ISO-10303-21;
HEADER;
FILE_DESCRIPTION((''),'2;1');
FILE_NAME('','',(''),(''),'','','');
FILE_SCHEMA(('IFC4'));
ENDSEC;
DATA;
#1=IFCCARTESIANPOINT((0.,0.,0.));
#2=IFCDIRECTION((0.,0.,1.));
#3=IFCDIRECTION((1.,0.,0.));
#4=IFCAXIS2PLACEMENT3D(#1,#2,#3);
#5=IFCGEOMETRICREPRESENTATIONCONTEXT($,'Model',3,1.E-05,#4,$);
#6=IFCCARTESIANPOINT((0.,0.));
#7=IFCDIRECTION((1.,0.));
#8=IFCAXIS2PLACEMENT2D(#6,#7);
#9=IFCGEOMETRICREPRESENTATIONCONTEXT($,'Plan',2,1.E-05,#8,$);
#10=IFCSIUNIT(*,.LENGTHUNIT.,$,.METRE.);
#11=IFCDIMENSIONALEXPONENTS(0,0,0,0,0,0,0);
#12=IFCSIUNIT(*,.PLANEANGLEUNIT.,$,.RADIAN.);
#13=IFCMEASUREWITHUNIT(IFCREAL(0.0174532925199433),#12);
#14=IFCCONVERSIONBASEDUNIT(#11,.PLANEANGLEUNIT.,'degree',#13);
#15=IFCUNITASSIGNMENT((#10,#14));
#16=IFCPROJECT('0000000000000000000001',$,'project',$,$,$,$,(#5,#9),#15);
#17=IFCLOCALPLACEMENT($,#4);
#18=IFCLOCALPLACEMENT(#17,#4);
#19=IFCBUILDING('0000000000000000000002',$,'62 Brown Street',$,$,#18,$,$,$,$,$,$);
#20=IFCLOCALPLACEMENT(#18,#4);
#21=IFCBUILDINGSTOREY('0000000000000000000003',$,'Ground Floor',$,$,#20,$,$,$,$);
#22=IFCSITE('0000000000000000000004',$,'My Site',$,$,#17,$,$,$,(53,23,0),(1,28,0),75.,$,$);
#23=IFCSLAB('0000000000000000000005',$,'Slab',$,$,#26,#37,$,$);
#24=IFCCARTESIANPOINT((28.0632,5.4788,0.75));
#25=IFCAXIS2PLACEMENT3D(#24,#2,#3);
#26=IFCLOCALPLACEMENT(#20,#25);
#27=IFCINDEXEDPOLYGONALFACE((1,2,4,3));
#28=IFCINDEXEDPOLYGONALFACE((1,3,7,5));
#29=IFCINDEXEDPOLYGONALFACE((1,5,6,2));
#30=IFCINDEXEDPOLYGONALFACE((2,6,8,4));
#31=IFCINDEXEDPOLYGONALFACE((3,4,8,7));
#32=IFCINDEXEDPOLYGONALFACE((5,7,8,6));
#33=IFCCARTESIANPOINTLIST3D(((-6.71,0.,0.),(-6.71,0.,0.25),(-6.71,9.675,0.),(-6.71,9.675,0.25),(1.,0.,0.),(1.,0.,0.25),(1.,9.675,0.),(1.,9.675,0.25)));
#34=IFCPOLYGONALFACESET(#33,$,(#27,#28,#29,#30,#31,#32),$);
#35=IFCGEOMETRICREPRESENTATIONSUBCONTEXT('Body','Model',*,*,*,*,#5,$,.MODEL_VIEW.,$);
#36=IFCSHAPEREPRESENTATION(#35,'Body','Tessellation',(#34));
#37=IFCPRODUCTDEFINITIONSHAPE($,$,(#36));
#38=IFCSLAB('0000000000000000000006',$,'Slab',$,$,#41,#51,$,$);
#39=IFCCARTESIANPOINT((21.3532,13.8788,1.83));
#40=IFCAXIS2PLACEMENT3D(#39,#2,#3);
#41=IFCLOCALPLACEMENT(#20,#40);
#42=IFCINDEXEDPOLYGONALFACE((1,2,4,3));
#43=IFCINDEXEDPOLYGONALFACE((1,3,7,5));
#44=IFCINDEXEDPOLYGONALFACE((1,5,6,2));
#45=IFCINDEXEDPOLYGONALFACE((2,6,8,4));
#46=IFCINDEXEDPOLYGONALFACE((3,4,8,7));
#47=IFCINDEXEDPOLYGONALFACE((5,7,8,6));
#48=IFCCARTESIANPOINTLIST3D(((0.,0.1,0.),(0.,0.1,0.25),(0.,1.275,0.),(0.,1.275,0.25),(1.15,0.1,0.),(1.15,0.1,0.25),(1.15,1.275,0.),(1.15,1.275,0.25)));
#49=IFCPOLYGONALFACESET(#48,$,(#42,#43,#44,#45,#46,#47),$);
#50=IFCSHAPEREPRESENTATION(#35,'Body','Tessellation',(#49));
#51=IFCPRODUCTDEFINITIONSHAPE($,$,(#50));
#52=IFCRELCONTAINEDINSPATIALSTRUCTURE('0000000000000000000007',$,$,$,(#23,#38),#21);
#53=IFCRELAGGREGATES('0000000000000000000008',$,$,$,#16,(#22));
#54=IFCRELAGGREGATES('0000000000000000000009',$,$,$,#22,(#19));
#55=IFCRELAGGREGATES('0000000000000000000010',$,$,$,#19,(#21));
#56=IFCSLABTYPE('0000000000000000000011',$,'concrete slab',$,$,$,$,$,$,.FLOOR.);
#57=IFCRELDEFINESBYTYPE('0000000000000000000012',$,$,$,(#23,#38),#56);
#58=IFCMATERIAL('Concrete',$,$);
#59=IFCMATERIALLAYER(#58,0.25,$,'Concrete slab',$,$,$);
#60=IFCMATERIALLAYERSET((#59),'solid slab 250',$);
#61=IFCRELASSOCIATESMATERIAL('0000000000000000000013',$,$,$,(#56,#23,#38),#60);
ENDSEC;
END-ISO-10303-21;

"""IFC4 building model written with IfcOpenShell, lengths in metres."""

from ifc_helpers import new_model, entity, si_unit, converted_unit, frame, origin_with_axes, origin_2d_with_axis, place, context, subcontext, project, spatial, indexed_curve, outline, extrude, material, layer, layer_set, layer_usage, type_object, element, save


model = new_model("IFC4")

# Units and contexts
model_context = context("Model", 3, precision=1e-05, world=origin_with_axes())
plan_context = context("Plan", 2, precision=1e-05, world=origin_2d_with_axis())
body_context_1 = subcontext(model_context, "Body", "Model", "MODEL_VIEW")
ifc_project = project(units=[si_unit("LENGTHUNIT", "METRE"), converted_unit("PLANEANGLEUNIT", "degree", entity("IfcReal", 0.0174532925199433), si_unit("PLANEANGLEUNIT", "RADIAN"), dimensions=[0, 0, 0, 0, 0, 0, 0])], contexts=[model_context, plan_context])

# Site, building, storey
site_placement = place(None, origin_with_axes())
site = spatial("IfcSite", under=ifc_project, at=site_placement, Name="My Site", RefLatitude=(53, 23, 0), RefLongitude=(1, 28, 0), RefElevation=75.0)
building_placement = place(site_placement, origin_with_axes())
building = spatial("IfcBuilding", under=site, at=building_placement, Name="62 Brown Street")
storey_placement = place(building_placement, origin_with_axes())
storey = spatial("IfcBuildingStorey", under=building, at=storey_placement, Name="Ground Floor")

# Shared definitions
ifc_material_1 = material(Name="Concrete")

# Slabs
ifc_layer_1 = layer(ifc_material_1, 0.25, Name="Concrete slab")
ifc_layer_set_1 = layer_set([ifc_layer_1], Name="solid slab 250")
slab_type = type_object("IfcSlabType", Name="concrete slab", PredefinedType="FLOOR", material=ifc_layer_set_1)
ifc_layer_usage_1 = layer_usage(ifc_layer_set_1, "AXIS3", "POSITIVE", 0.0)
slab_1_placement = place(storey_placement, frame((28.0632, 5.4788, 0.75), z_axis=(0.0, 0.0, 1.0), x_axis=(1.0, 0.0, 0.0)))
element("IfcSlab", 1, at=slab_1_placement, inside=storey, type_object=slab_type, material=ifc_layer_usage_1, Name="Slab", context=body_context_1, shape_type="SweptSolid", body=[
    extrude(outline(indexed_curve([(-6.71, 0.0), (-6.71, 9.675), (1.0, 9.675), (1.0, 0.0), (-6.71, 0.0)])), None, (0.0, 0.0, 1.0), 0.25),
])
ifc_layer_usage_2 = layer_usage(ifc_layer_set_1, "AXIS3", "POSITIVE", 0.0)
slab_2_placement = place(storey_placement, frame((21.3532, 13.8788, 1.83), z_axis=(0.0, 0.0, 1.0), x_axis=(1.0, 0.0, 0.0)))
element("IfcSlab", 2, at=slab_2_placement, inside=storey, type_object=slab_type, material=ifc_layer_usage_2, Name="Slab", context=body_context_1, shape_type="SweptSolid", body=[
    extrude(outline(indexed_curve([(0.0, 1.275), (1.15, 1.275), (1.15, 0.1), (0.0, 0.1), (0.0, 1.275)])), None, (0.0, 0.0, 1.0), 0.25),
])

save(model, "model.ifc")
